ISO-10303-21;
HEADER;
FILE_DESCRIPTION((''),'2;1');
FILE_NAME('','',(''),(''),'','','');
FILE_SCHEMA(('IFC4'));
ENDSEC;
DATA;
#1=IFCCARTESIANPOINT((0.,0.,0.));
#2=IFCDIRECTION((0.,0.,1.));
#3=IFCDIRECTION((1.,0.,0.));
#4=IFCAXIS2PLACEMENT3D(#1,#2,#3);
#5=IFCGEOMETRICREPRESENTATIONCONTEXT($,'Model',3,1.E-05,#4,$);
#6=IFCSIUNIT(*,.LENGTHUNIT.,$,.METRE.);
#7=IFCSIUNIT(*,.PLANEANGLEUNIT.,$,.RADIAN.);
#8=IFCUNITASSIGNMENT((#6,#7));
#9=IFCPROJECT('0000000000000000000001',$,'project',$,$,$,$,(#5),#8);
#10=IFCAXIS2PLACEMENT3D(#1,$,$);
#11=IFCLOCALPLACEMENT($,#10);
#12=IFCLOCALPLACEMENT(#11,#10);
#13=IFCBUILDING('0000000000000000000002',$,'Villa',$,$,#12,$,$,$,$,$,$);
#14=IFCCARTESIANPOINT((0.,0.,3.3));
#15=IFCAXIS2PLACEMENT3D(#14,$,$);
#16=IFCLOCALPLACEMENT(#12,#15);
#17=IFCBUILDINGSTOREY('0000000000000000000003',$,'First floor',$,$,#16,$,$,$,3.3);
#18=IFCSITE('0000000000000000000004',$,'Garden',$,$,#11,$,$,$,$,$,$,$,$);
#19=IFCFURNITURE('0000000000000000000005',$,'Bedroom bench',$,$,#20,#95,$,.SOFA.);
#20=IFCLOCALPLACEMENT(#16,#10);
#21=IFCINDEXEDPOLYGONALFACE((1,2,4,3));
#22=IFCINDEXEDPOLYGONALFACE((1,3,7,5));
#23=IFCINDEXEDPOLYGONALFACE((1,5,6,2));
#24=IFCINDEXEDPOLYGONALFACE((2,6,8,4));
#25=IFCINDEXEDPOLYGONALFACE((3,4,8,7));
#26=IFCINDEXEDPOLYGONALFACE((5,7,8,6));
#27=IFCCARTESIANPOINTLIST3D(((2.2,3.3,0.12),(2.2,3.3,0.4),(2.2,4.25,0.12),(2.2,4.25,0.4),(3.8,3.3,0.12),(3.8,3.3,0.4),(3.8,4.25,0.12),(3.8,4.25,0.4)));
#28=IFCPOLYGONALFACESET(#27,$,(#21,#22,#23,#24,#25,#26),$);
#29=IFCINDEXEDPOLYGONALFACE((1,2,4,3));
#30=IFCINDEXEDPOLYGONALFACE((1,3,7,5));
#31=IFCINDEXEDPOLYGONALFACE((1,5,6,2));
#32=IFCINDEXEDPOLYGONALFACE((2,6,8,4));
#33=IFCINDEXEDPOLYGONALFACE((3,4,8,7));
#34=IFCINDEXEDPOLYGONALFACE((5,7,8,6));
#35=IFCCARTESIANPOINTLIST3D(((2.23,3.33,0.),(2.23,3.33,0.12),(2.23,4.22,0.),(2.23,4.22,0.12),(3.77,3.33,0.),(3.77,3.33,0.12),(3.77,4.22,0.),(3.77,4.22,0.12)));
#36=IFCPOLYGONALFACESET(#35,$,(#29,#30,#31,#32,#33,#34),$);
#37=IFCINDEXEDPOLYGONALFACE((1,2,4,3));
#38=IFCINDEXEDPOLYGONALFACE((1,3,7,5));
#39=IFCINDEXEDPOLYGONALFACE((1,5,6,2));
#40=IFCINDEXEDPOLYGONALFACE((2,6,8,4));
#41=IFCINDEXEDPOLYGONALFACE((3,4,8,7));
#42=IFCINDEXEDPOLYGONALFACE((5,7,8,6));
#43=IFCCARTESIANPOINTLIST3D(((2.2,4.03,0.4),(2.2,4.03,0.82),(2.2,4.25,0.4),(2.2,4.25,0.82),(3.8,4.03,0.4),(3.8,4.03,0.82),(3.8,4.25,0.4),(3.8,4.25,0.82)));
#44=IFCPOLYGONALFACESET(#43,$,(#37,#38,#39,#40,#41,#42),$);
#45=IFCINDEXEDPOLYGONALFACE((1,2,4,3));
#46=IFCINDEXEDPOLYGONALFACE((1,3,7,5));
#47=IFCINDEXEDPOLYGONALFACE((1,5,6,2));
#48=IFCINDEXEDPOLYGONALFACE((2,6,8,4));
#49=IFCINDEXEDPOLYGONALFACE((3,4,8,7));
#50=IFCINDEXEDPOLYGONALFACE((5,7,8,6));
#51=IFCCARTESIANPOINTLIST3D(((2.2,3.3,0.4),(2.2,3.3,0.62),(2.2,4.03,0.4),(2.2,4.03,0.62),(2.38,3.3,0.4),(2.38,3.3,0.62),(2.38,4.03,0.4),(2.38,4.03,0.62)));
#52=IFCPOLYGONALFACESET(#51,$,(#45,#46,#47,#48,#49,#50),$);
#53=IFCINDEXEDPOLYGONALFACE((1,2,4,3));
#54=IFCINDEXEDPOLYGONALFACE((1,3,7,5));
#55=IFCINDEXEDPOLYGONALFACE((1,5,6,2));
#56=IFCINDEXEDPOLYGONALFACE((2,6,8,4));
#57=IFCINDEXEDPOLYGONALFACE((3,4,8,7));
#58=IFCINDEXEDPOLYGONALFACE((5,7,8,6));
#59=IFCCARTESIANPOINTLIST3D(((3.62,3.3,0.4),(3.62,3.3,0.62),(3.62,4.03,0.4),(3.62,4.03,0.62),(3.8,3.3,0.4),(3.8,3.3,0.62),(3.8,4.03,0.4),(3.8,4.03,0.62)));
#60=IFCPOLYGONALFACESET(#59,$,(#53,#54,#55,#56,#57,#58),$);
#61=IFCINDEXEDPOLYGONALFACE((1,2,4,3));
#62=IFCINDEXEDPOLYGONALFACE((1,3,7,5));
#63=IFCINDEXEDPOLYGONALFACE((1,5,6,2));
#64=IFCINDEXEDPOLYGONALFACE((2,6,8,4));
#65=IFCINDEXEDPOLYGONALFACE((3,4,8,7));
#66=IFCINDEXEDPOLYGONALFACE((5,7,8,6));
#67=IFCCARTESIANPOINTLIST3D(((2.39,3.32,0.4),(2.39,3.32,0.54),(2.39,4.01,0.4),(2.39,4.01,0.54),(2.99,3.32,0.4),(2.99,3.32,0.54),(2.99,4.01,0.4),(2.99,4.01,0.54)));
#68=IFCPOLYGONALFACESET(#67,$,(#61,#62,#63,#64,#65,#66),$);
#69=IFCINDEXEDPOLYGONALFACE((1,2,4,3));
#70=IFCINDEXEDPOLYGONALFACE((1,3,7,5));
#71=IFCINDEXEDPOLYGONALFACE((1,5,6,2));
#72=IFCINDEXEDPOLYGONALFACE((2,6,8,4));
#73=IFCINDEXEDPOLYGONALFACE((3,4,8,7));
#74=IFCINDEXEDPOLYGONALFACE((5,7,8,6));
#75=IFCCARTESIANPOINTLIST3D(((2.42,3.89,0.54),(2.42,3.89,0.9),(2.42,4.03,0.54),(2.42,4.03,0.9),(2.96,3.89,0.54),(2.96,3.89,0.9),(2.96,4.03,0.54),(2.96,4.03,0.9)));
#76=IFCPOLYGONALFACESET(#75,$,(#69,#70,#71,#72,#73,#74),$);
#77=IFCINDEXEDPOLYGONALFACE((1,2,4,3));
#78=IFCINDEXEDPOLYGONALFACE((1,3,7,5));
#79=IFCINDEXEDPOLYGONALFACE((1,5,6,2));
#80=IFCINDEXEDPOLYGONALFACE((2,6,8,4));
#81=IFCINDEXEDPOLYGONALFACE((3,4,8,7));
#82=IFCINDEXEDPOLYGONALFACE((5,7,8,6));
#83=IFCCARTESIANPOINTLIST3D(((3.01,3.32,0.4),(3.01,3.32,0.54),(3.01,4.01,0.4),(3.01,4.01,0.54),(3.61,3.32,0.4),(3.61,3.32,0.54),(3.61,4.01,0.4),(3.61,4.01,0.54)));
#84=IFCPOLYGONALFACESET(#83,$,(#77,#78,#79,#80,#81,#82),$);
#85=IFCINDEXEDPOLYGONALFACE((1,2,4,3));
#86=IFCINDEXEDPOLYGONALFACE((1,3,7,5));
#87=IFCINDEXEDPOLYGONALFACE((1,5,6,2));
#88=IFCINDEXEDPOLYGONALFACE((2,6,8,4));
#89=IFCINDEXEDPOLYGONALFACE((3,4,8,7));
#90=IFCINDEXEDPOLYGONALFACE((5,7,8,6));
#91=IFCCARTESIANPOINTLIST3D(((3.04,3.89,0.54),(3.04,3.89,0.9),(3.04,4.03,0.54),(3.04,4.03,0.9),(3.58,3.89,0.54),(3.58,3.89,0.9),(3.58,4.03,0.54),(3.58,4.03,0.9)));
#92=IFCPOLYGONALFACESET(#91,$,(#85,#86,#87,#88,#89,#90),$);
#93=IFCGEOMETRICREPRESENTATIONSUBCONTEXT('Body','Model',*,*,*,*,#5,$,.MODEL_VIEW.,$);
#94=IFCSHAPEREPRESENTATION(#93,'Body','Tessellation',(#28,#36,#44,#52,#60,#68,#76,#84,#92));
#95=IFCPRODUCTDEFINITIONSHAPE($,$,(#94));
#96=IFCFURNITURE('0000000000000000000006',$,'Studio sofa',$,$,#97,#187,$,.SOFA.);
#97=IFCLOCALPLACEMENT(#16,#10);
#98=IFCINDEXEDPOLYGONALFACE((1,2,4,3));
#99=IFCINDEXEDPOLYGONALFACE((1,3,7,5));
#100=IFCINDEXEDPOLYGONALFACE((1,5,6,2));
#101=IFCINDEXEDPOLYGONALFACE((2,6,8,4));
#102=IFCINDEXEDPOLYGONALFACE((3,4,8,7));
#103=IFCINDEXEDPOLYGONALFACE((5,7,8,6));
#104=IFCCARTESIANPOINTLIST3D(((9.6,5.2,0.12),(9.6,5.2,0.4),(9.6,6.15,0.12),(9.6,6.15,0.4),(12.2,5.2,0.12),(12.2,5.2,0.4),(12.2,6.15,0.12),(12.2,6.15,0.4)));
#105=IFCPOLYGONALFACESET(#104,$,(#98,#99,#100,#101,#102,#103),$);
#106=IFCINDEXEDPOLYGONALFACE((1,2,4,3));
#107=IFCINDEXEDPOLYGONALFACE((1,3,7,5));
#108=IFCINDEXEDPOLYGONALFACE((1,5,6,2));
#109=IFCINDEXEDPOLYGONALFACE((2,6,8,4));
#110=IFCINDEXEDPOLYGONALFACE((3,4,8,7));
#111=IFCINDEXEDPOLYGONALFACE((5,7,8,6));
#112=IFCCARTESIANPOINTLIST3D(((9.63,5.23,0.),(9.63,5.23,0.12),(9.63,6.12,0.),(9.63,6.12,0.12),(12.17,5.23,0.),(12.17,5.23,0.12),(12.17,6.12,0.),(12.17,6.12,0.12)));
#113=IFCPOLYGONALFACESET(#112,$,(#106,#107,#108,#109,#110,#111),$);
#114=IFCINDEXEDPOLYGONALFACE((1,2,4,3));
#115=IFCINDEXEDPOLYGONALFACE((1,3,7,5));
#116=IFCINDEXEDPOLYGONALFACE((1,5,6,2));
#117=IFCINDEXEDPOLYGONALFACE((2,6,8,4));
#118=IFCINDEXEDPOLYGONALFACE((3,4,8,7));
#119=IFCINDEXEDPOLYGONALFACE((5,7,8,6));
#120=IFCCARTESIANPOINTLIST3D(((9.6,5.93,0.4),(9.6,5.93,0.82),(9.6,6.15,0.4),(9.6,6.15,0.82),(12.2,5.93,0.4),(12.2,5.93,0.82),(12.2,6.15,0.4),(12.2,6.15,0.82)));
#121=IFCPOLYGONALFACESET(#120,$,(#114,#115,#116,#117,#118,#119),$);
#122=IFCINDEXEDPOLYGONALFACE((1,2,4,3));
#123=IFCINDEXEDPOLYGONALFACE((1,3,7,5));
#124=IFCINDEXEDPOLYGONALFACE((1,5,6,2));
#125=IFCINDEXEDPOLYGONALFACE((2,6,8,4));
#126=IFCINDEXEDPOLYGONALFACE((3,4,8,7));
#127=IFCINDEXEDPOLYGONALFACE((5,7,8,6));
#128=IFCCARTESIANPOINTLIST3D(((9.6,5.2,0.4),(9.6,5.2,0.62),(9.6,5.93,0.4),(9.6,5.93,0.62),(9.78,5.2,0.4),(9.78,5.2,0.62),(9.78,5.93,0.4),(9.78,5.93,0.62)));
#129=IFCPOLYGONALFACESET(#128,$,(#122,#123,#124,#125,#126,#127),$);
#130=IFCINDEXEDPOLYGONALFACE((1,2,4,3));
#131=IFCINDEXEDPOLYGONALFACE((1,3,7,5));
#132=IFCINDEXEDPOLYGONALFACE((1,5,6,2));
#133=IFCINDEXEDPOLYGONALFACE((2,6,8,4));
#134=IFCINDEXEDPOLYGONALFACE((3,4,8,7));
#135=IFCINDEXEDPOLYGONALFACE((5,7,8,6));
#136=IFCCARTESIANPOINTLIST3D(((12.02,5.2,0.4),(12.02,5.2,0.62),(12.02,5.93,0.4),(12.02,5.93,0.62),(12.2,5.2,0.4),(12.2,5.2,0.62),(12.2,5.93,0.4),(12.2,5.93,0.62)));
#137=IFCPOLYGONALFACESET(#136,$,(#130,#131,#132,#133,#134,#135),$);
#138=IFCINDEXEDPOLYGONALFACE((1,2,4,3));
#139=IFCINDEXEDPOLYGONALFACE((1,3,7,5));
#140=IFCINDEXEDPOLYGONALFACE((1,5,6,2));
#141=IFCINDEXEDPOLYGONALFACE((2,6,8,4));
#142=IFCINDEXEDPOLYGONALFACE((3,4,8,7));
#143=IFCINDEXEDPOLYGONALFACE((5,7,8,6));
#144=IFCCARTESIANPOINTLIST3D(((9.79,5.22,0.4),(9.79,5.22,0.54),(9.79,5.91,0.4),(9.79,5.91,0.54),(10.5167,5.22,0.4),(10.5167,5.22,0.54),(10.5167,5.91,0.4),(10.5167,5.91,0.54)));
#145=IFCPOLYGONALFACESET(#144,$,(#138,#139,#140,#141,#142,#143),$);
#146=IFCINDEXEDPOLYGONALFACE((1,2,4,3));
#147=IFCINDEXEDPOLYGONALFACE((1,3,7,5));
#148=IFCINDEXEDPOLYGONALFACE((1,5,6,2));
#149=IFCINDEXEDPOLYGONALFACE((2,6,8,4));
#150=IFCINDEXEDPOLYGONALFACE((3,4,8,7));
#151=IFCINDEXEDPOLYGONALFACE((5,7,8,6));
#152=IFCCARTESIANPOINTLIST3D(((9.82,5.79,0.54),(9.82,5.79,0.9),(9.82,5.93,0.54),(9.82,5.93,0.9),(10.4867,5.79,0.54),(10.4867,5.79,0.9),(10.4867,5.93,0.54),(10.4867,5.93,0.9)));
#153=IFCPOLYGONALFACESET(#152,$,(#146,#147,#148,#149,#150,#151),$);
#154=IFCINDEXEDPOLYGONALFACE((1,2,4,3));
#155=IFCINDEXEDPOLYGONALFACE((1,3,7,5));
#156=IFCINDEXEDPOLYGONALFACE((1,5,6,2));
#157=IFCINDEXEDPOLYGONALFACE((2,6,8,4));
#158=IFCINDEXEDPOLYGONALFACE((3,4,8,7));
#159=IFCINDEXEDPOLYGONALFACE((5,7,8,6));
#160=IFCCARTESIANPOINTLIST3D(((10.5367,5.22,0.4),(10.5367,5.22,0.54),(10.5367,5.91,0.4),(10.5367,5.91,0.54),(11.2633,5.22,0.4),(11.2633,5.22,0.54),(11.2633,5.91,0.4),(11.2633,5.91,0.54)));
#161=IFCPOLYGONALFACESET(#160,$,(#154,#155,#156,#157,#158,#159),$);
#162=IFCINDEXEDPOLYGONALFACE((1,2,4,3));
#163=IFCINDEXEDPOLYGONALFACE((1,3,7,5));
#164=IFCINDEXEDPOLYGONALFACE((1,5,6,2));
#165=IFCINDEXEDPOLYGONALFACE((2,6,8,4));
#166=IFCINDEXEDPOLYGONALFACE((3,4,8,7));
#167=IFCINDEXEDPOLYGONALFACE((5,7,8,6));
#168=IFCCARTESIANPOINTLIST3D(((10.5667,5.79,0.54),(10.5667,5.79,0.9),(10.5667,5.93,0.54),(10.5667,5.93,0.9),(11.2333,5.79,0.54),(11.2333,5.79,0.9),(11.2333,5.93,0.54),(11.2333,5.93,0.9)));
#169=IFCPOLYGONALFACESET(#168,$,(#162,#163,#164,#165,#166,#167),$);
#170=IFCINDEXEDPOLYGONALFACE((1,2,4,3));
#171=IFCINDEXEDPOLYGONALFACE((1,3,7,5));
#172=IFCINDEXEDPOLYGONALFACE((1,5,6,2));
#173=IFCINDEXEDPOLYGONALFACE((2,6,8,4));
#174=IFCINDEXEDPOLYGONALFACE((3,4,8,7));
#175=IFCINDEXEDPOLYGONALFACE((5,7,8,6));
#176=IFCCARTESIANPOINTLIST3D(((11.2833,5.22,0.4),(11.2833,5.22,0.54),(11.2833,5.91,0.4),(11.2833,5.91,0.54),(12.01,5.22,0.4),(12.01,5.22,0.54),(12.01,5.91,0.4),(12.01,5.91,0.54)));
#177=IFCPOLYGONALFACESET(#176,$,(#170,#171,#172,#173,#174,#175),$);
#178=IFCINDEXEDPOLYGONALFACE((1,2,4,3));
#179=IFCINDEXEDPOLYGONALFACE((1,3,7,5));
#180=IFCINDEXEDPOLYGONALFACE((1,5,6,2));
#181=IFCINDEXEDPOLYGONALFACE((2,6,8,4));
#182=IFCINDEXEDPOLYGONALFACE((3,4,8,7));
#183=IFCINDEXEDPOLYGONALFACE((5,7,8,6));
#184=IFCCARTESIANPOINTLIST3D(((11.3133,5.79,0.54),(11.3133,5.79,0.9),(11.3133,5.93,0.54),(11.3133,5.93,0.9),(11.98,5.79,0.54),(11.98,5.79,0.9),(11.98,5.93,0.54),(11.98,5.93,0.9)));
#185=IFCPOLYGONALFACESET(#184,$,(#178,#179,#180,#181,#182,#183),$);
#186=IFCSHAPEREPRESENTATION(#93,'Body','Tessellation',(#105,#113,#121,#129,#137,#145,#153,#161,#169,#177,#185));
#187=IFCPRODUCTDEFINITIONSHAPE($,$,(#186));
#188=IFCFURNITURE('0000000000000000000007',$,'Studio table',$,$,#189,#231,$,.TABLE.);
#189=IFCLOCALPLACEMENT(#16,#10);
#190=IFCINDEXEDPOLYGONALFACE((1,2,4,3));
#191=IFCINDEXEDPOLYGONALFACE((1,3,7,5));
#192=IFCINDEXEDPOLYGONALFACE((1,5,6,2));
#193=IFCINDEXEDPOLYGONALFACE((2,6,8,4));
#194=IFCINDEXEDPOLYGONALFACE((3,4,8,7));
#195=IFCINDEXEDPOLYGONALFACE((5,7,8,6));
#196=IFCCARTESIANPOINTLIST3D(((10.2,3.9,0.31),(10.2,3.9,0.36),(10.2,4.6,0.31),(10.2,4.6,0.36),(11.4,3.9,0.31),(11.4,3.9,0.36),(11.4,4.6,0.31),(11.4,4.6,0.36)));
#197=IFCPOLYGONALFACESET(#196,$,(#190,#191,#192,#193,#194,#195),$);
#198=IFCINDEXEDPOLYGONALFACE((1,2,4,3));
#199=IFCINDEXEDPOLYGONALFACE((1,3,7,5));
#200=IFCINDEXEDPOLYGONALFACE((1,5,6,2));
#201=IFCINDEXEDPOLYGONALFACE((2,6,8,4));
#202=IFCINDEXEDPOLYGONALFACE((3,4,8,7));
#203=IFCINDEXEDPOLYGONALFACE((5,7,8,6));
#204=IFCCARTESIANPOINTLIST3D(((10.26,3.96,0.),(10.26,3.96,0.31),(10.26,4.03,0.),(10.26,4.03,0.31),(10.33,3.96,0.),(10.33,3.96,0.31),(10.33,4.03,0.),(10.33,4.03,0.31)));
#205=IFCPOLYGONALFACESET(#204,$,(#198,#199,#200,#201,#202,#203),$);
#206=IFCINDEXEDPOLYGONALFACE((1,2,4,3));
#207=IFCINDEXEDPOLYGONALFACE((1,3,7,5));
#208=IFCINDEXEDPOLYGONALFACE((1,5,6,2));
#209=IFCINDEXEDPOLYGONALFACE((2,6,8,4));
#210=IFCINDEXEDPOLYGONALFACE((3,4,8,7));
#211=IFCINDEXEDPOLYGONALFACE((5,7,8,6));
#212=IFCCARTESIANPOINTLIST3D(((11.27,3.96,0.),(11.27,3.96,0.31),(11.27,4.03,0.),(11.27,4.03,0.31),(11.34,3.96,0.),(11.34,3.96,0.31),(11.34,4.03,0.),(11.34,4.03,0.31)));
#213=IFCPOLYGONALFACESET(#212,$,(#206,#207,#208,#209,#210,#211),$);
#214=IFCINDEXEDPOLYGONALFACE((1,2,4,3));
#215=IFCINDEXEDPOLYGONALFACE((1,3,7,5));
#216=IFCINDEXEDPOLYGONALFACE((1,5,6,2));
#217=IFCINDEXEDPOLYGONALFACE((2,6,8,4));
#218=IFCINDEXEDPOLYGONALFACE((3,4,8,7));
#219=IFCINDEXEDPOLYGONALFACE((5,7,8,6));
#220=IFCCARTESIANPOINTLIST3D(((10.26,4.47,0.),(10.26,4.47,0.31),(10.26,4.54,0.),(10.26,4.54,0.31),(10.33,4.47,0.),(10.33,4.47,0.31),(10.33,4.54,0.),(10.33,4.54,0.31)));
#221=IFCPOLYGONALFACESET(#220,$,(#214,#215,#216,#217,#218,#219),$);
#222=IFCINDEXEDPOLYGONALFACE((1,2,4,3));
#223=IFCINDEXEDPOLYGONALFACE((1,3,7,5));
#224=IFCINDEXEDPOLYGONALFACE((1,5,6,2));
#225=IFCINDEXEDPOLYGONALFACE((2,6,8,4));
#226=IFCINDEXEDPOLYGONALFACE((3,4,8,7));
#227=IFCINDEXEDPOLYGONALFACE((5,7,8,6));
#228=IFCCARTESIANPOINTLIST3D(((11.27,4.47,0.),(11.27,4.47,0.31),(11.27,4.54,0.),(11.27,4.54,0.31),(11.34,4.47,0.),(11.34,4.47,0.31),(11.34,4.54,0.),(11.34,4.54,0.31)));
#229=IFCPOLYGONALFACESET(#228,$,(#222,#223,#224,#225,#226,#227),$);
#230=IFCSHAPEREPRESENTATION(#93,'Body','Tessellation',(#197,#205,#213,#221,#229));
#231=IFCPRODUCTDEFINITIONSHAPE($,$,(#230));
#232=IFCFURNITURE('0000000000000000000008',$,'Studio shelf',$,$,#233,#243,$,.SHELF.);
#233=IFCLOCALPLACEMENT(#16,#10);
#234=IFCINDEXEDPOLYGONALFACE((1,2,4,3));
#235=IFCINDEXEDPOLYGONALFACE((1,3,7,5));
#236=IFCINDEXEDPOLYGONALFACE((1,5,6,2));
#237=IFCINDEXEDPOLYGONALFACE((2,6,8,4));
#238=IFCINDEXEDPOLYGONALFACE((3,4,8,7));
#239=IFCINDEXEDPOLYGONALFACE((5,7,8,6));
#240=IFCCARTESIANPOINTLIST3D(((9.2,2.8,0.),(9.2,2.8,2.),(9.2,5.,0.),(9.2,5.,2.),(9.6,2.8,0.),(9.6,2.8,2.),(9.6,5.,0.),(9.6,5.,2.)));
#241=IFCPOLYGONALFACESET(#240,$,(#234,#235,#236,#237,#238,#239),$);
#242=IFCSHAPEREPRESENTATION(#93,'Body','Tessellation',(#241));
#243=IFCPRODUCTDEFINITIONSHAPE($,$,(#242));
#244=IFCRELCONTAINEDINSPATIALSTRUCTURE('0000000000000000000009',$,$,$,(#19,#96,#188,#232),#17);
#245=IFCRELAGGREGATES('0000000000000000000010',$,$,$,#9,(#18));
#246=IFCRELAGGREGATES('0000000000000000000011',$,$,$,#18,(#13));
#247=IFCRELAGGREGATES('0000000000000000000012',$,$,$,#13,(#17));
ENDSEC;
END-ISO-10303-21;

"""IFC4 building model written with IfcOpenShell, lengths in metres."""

from ifc_helpers import new_model, si_unit, frame, frame_2d, origin, origin_with_axes, place, context, subcontext, project, spatial, rectangle, extrude, element, save


model = new_model("IFC4")

# Units and contexts
model_context = context("Model", 3, precision=1e-05, world=origin_with_axes())
body_context = subcontext(model_context, "Body", "Model", "MODEL_VIEW")
ifc_project = project(units=[si_unit("LENGTHUNIT", "METRE"), si_unit("PLANEANGLEUNIT", "RADIAN")], contexts=[model_context])

# Site, building, storey
site_placement = place(None, origin())
site = spatial("IfcSite", under=ifc_project, at=site_placement, Name="Garden")
building_placement = place(site_placement, origin())
building = spatial("IfcBuilding", under=site, at=building_placement, Name="Villa")
storey_placement = place(building_placement, frame((0.0, 0.0, 3.3)))
storey = spatial("IfcBuildingStorey", under=building, at=storey_placement, Name="First floor", Elevation=3.3)

# Furniture
furniture_1_placement = place(storey_placement, frame((2.2, 3.3, 0.0)))
element("IfcFurniture", 1, at=furniture_1_placement, inside=storey, Name="Bedroom bench", PredefinedType="SOFA", context=body_context, shape_type="SweptSolid", body=[
    extrude(rectangle(XDim=1.6, YDim=0.95, at=frame_2d((0.8, 0.475))), frame((0.0, 0.0, 0.12)), (0.0, 0.0, 1.0), 0.28),
    extrude(rectangle(XDim=1.54, YDim=0.89, at=frame_2d((0.77, 0.445))), frame((0.03, 0.03, 0.0)), (0.0, 0.0, 1.0), 0.12),
    extrude(rectangle(XDim=1.6, YDim=0.22, at=frame_2d((0.8, 0.11))), frame((0.0, 0.73, 0.4)), (0.0, 0.0, 1.0), 0.42),
    extrude(rectangle(XDim=0.18, YDim=0.73, at=frame_2d((0.09, 0.365))), frame((0.0, 0.0, 0.4)), (0.0, 0.0, 1.0), 0.22),
    extrude(rectangle(XDim=0.18, YDim=0.73, at=frame_2d((0.09, 0.365))), frame((1.42, 0.0, 0.4)), (0.0, 0.0, 1.0), 0.22),
    extrude(rectangle(XDim=0.6, YDim=0.69, at=frame_2d((0.3, 0.345))), frame((0.19, 0.02, 0.4)), (0.0, 0.0, 1.0), 0.14),
    extrude(rectangle(XDim=0.54, YDim=0.14, at=frame_2d((0.27, 0.07))), frame((0.22, 0.59, 0.54)), (0.0, 0.0, 1.0), 0.36),
    extrude(rectangle(XDim=0.6, YDim=0.69, at=frame_2d((0.3, 0.345))), frame((0.81, 0.02, 0.4)), (0.0, 0.0, 1.0), 0.14),
    extrude(rectangle(XDim=0.54, YDim=0.14, at=frame_2d((0.27, 0.07))), frame((0.84, 0.59, 0.54)), (0.0, 0.0, 1.0), 0.36),
])
furniture_2_placement = place(storey_placement, frame((9.6, 5.2, 0.0)))
element("IfcFurniture", 2, at=furniture_2_placement, inside=storey, Name="Studio sofa", PredefinedType="SOFA", context=body_context, shape_type="SweptSolid", body=[
    extrude(rectangle(XDim=2.6, YDim=0.95, at=frame_2d((1.3, 0.475))), frame((0.0, 0.0, 0.12)), (0.0, 0.0, 1.0), 0.28),
    extrude(rectangle(XDim=2.54, YDim=0.89, at=frame_2d((1.27, 0.445))), frame((0.03, 0.03, 0.0)), (0.0, 0.0, 1.0), 0.12),
    extrude(rectangle(XDim=2.6, YDim=0.22, at=frame_2d((1.3, 0.11))), frame((0.0, 0.73, 0.4)), (0.0, 0.0, 1.0), 0.42),
    extrude(rectangle(XDim=0.18, YDim=0.73, at=frame_2d((0.09, 0.365))), frame((0.0, 0.0, 0.4)), (0.0, 0.0, 1.0), 0.22),
    extrude(rectangle(XDim=0.18, YDim=0.73, at=frame_2d((0.09, 0.365))), frame((2.42, 0.0, 0.4)), (0.0, 0.0, 1.0), 0.22),
    extrude(rectangle(XDim=0.7267, YDim=0.69, at=frame_2d((0.3633, 0.345))), frame((0.19, 0.02, 0.4)), (0.0, 0.0, 1.0), 0.14),
    extrude(rectangle(XDim=0.6667, YDim=0.14, at=frame_2d((0.3333, 0.07))), frame((0.22, 0.59, 0.54)), (0.0, 0.0, 1.0), 0.36),
    extrude(rectangle(XDim=0.7267, YDim=0.69, at=frame_2d((0.3633, 0.345))), frame((0.9367, 0.02, 0.4)), (0.0, 0.0, 1.0), 0.14),
    extrude(rectangle(XDim=0.6667, YDim=0.14, at=frame_2d((0.3333, 0.07))), frame((0.9667, 0.59, 0.54)), (0.0, 0.0, 1.0), 0.36),
    extrude(rectangle(XDim=0.7267, YDim=0.69, at=frame_2d((0.3633, 0.345))), frame((1.6833, 0.02, 0.4)), (0.0, 0.0, 1.0), 0.14),
    extrude(rectangle(XDim=0.6667, YDim=0.14, at=frame_2d((0.3333, 0.07))), frame((1.7133, 0.59, 0.54)), (0.0, 0.0, 1.0), 0.36),
])
furniture_3_placement = place(storey_placement, frame((10.2, 3.9, 0.0)))
element("IfcFurniture", 3, at=furniture_3_placement, inside=storey, Name="Studio table", PredefinedType="TABLE", context=body_context, shape_type="SweptSolid", body=[
    extrude(rectangle(XDim=1.2, YDim=0.7, at=frame_2d((0.6, 0.35))), frame((0.0, 0.0, 0.31)), (0.0, 0.0, 1.0), 0.05),
    extrude(rectangle(XDim=0.07, YDim=0.07, at=frame_2d((0.035, 0.035))), frame((0.06, 0.06, 0.0)), (0.0, 0.0, 1.0), 0.31),
    extrude(rectangle(XDim=0.07, YDim=0.07, at=frame_2d((0.035, 0.035))), frame((1.07, 0.06, 0.0)), (0.0, 0.0, 1.0), 0.31),
    extrude(rectangle(XDim=0.07, YDim=0.07, at=frame_2d((0.035, 0.035))), frame((0.06, 0.57, 0.0)), (0.0, 0.0, 1.0), 0.31),
    extrude(rectangle(XDim=0.07, YDim=0.07, at=frame_2d((0.035, 0.035))), frame((1.07, 0.57, 0.0)), (0.0, 0.0, 1.0), 0.31),
])
furniture_4_placement = place(storey_placement, frame((9.6, 2.8, 0.0), x_axis=(0.0, 1.0, 0.0)))
element("IfcFurniture", 4, at=furniture_4_placement, inside=storey, Name="Studio shelf", PredefinedType="SHELF", context=body_context, shape_type="SweptSolid", body=[
    extrude(rectangle(XDim=2.2, YDim=0.4, at=frame_2d((1.1, 0.2))), origin(), (0.0, 0.0, 1.0), 2.0),
])

save(model, "model.ifc")
